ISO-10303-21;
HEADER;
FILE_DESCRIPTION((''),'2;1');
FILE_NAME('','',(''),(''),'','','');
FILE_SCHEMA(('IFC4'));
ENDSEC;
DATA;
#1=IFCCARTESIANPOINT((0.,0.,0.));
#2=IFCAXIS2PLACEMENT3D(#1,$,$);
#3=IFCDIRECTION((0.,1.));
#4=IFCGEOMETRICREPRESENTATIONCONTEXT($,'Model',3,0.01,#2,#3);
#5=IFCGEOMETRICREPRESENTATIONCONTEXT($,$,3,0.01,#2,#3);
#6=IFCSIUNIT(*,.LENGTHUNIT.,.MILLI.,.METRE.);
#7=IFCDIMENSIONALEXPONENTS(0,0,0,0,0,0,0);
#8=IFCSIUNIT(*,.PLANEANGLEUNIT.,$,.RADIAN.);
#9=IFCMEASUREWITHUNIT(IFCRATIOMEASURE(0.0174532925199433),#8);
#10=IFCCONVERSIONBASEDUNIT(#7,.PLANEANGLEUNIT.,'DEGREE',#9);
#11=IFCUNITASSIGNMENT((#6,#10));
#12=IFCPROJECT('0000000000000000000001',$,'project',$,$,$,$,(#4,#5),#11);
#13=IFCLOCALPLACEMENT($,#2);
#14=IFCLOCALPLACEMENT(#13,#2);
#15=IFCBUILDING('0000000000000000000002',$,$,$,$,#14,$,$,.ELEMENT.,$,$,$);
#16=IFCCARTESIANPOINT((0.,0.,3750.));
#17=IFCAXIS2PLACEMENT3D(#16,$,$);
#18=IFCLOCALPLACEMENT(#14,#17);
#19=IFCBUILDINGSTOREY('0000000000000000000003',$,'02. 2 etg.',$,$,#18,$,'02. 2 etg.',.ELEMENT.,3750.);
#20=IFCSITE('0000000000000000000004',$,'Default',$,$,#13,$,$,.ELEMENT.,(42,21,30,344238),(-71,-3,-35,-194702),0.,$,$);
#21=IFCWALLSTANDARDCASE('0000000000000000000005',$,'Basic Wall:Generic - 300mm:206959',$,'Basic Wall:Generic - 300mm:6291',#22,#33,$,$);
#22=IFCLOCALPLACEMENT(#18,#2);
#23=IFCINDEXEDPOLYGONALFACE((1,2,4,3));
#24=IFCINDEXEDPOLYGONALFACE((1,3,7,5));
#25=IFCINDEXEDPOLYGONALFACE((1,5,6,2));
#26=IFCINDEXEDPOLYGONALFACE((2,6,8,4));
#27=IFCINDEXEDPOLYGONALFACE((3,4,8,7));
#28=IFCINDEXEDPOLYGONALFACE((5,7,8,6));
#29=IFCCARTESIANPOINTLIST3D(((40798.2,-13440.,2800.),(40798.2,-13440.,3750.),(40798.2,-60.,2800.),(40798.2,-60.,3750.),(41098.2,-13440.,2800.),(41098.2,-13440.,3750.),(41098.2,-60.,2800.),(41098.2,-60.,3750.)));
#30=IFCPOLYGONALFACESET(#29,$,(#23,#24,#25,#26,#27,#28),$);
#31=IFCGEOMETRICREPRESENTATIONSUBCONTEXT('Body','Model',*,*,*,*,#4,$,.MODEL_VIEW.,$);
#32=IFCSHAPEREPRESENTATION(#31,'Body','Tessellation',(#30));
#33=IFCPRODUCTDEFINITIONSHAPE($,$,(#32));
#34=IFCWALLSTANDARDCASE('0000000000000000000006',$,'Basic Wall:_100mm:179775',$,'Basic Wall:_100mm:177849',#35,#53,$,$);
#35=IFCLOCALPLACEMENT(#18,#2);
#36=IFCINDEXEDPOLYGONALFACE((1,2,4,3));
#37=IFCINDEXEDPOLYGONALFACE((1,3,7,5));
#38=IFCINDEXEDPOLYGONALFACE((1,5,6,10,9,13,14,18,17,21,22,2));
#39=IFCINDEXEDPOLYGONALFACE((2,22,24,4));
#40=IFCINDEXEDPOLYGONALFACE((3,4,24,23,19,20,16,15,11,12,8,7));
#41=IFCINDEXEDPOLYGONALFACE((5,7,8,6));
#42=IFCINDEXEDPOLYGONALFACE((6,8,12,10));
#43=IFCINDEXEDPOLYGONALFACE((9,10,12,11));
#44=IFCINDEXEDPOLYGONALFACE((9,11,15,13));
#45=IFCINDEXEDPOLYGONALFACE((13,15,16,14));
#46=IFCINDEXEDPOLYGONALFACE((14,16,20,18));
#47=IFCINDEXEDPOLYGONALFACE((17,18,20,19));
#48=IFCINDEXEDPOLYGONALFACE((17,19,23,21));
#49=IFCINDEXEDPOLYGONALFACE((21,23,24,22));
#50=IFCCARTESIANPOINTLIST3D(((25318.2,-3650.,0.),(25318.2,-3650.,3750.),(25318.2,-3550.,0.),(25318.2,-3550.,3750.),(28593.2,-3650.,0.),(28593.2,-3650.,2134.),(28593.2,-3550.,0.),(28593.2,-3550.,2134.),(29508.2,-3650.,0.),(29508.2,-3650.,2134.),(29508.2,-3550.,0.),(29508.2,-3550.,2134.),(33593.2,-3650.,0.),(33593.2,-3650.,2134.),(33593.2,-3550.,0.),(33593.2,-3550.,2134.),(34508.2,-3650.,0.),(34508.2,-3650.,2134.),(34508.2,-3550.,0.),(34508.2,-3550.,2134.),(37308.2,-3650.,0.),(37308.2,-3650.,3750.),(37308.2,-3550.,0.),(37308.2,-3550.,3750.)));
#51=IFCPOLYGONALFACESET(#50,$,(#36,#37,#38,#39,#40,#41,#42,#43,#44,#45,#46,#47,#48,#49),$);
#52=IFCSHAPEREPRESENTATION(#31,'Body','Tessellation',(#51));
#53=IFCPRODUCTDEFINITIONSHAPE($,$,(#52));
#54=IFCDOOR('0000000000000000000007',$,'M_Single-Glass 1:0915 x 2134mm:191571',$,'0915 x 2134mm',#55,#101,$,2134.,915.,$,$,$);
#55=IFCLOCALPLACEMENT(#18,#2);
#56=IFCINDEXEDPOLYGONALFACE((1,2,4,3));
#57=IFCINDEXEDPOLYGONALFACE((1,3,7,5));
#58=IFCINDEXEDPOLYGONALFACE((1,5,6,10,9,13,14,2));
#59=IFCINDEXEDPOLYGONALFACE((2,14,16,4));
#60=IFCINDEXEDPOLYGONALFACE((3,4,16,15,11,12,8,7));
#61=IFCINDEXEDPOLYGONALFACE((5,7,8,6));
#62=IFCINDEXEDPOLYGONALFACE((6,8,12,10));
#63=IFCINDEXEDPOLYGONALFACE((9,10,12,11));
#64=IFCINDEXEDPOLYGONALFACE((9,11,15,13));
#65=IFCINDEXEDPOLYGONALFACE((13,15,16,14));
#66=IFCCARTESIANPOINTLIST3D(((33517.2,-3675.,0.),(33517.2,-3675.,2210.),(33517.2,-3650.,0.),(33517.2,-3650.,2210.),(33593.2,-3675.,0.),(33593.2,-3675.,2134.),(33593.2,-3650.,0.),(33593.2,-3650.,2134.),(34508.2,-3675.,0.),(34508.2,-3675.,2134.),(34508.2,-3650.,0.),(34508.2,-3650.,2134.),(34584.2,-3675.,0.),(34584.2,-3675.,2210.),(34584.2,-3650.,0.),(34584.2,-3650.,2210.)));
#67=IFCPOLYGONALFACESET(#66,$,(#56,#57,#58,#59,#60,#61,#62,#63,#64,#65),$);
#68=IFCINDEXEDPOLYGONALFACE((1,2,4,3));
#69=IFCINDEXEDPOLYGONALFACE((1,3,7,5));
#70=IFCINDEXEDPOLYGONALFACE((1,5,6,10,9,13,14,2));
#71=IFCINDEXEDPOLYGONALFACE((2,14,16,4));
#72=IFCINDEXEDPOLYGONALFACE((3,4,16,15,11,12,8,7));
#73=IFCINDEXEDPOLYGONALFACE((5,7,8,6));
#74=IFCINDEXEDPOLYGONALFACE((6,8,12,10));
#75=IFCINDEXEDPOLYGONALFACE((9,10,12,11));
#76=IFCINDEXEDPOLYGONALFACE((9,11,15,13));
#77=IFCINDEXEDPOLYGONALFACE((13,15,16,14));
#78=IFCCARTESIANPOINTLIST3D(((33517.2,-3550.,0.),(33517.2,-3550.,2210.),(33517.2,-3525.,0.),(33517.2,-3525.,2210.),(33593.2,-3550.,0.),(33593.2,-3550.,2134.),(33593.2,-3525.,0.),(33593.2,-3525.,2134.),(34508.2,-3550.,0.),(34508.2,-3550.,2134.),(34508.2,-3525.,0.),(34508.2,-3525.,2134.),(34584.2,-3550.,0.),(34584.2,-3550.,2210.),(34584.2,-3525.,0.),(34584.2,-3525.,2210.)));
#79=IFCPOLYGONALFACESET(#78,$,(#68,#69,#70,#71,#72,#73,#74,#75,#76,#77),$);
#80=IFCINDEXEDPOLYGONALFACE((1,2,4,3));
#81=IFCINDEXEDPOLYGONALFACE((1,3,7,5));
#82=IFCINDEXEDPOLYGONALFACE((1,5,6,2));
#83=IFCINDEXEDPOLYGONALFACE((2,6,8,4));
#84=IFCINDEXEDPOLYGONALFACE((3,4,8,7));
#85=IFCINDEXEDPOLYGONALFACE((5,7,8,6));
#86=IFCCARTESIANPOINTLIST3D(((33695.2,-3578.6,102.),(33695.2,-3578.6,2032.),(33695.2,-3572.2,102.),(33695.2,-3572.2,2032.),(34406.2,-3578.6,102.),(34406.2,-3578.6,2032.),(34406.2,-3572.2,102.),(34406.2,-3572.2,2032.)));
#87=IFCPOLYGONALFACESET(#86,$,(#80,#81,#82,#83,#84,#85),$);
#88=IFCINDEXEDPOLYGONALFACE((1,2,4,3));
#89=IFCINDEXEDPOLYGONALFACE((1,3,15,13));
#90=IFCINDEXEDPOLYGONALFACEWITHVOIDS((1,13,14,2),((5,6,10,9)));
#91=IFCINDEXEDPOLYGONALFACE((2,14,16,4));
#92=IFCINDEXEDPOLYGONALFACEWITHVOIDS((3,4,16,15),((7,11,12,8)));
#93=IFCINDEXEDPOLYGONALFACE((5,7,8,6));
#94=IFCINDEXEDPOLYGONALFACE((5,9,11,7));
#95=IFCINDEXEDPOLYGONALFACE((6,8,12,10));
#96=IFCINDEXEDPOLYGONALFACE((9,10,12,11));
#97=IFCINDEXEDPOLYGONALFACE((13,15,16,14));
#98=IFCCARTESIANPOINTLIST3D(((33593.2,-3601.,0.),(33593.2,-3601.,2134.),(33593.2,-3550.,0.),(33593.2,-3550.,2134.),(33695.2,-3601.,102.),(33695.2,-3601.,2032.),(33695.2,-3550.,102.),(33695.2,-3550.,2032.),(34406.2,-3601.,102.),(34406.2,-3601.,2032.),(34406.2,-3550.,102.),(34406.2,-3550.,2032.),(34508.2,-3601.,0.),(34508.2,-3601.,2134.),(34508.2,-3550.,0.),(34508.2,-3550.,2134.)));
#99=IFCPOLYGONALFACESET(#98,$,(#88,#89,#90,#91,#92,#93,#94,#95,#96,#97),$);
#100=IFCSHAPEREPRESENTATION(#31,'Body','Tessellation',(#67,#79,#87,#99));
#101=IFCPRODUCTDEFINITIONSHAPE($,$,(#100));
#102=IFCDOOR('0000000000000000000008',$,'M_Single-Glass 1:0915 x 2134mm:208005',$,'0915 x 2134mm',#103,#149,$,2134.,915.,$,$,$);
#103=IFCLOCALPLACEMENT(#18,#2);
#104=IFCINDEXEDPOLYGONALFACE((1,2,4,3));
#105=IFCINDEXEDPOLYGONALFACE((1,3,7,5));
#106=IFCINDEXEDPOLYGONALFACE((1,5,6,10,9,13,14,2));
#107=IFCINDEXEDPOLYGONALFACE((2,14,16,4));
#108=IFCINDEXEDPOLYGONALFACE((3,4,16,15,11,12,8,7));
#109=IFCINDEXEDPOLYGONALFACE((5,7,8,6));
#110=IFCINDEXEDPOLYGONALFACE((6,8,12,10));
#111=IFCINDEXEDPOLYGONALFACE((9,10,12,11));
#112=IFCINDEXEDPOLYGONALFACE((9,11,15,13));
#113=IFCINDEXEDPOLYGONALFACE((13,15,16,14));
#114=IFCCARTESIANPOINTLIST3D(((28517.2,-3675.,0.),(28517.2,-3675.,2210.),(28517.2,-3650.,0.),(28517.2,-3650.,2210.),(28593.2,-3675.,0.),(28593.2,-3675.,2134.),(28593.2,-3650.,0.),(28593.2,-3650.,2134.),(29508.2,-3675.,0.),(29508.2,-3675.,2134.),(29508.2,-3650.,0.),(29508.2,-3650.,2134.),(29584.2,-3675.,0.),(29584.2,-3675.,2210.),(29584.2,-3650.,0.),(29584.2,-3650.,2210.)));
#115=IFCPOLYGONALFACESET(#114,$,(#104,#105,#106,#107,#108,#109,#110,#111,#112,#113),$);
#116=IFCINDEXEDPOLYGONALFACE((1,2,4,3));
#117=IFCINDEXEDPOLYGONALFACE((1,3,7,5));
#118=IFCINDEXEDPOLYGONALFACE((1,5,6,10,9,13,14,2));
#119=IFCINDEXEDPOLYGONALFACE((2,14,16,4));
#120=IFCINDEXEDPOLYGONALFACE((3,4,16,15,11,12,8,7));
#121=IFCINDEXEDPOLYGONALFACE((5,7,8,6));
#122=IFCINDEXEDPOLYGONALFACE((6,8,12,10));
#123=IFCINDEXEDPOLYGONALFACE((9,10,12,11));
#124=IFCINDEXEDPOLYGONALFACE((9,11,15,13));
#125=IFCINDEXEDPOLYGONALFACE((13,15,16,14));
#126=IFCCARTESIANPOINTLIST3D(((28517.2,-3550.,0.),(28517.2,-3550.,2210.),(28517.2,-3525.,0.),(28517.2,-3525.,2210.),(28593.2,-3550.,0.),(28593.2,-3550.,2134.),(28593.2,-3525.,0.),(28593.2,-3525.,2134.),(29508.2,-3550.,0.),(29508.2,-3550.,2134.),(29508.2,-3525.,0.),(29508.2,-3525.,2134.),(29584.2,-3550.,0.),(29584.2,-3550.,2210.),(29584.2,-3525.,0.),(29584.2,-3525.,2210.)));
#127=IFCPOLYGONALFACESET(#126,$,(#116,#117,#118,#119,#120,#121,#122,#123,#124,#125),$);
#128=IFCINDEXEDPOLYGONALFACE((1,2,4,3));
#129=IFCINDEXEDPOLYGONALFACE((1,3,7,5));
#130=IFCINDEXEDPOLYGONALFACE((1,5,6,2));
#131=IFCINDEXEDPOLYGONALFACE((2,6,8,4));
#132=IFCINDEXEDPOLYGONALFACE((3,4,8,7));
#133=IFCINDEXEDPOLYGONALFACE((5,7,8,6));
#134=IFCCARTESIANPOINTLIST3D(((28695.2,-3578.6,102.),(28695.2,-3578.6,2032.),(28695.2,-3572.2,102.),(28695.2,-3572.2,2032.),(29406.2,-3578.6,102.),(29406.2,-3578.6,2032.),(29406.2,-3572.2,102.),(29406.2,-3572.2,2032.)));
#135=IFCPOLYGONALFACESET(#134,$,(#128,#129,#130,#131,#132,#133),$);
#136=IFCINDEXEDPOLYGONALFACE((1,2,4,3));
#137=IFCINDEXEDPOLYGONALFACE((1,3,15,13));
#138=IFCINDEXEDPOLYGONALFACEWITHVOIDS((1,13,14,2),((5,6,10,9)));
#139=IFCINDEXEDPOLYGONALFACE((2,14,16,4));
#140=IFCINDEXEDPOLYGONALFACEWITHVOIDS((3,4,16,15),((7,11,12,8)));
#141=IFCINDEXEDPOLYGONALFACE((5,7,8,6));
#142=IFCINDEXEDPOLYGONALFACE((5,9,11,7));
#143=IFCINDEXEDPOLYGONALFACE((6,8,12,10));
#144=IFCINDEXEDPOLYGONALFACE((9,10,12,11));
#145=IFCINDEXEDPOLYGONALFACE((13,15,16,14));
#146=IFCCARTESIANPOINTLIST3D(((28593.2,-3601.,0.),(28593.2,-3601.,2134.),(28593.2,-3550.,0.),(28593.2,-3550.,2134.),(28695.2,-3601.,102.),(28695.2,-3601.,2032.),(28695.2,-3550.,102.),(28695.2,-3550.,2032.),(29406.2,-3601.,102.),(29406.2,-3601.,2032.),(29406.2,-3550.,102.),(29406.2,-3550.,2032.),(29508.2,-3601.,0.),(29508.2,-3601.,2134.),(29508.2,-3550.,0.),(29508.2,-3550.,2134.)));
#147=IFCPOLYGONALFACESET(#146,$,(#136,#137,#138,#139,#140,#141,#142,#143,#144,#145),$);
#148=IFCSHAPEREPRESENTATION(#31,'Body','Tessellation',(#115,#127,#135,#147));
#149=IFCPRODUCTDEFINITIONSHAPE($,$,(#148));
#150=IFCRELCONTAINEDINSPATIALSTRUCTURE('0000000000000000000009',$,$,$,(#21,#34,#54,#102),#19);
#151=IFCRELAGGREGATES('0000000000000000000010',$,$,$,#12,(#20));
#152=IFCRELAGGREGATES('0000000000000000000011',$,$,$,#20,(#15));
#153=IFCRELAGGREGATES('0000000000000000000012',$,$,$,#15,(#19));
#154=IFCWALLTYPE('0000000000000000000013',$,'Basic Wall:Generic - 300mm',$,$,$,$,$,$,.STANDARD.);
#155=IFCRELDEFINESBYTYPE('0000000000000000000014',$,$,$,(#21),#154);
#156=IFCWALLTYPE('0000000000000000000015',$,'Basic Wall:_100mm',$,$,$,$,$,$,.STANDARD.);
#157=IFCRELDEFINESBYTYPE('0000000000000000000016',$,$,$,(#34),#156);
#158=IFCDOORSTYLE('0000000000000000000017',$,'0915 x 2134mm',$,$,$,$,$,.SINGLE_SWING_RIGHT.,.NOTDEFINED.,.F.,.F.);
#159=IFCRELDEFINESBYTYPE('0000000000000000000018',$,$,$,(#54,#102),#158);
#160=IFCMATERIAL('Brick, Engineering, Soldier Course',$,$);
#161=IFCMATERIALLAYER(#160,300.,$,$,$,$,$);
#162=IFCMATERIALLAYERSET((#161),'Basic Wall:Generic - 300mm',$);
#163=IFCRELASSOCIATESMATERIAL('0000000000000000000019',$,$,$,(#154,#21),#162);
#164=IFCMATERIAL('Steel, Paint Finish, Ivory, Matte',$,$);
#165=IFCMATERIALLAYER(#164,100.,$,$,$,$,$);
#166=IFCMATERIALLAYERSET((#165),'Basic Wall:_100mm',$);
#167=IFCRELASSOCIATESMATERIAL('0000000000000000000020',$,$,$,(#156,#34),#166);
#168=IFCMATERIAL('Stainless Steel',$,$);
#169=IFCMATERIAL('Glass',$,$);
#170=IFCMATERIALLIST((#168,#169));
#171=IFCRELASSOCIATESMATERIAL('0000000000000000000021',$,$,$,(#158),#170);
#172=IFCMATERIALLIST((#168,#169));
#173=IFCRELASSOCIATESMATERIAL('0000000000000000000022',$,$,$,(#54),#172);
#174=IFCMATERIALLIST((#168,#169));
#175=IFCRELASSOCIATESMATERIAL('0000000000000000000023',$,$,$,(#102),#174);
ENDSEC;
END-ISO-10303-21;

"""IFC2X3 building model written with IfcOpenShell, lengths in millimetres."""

from ifc_helpers import new_model, entity, si_unit, converted_unit, direction, frame, frame_2d, origin, place, context, subcontext, project, spatial, polyline, rectangle, outline, extrude, source, transform, mapped, material, material_list, layer, layer_set, layer_usage, type_object, type_shapes, element, fill, save


model = new_model("IFC2X3")

# Units and contexts
model_context = context("Model", 3, precision=0.01, world=origin(), true_north=direction((0.0, 1.0)))
context_of_model = context(None, 3, precision=0.01, world=origin(), true_north=direction((0.0, 1.0)))
body_context = subcontext(model_context, "Body", "Model", "MODEL_VIEW")
ifc_project = project(units=[si_unit("LENGTHUNIT", "METRE", prefix="MILLI"), converted_unit("PLANEANGLEUNIT", "DEGREE", entity("IfcRatioMeasure", 0.0174532925199433), si_unit("PLANEANGLEUNIT", "RADIAN"), dimensions=[0, 0, 0, 0, 0, 0, 0])], contexts=[model_context, context_of_model])

# Site, building, storey
site_placement = place(None, origin())
site = spatial("IfcSite", under=ifc_project, at=site_placement, Name="Default", CompositionType="ELEMENT", RefLatitude=(42, 21, 30, 344238), RefLongitude=(-71, -3, -35, -194702), RefElevation=0.0)
building_placement = place(site_placement, origin())
building = spatial("IfcBuilding", under=site, at=building_placement, CompositionType="ELEMENT")
storey_placement = place(building_placement, frame((0.0, 0.0, 3750.0)))
storey = spatial("IfcBuildingStorey", under=building, at=storey_placement, Name="02. 2 etg.", LongName="02. 2 etg.", CompositionType="ELEMENT", Elevation=3750.0)

# Shared definitions
ifc_material_1 = material(Name="Brick, Engineering, Soldier Course")
ifc_layer_1 = layer(ifc_material_1, 300.0)
ifc_layer_set_1 = layer_set([ifc_layer_1], Name="Basic Wall:Generic - 300mm")
wall_type_1 = type_object("IfcWallType", Name="Basic Wall:Generic - 300mm", PredefinedType="STANDARD", material=ifc_layer_set_1)

# Shared definitions
ifc_material_2 = material(Name="Glass")
ifc_material_3 = material(Name="Stainless Steel")

# Wall
ifc_layer_usage_1 = layer_usage(ifc_layer_set_1, "AXIS2", "POSITIVE", -150.0)
wall_1_placement = place(storey_placement, frame((40948.2, -60.0, 2800.0), z_axis=(0.0, 0.0, 1.0), x_axis=(0.0, -1.0, 0.0)))
element("IfcWallStandardCase", 1, at=wall_1_placement, inside=storey, type_object=wall_type_1, material=ifc_layer_usage_1, Name="Basic Wall:Generic - 300mm:206959", ObjectType="Basic Wall:Generic - 300mm:6291", context=body_context, shape_type="SweptSolid", body=[
    extrude(rectangle(XDim=13380.0, YDim=300.0, at=frame_2d((6690.0, 0.0), x_axis=(-1.0, 0.0))), origin(), (0.0, 0.0, 1.0), 950.0),
])

# Wall, openings, doors
ifc_material_4 = material(Name="Steel, Paint Finish, Ivory, Matte")
ifc_layer_2 = layer(ifc_material_4, 100.0)
ifc_layer_set_2 = layer_set([ifc_layer_2], Name="Basic Wall:_100mm")
ifc_layer_usage_2 = layer_usage(ifc_layer_set_2, "AXIS2", "POSITIVE", -50.0)
wall_type_2 = type_object("IfcWallType", Name="Basic Wall:_100mm", PredefinedType="STANDARD", material=ifc_layer_set_2)
wall_2_placement = place(storey_placement, frame((25318.2, -3600.0, 0.0)))
wall_2 = element("IfcWallStandardCase", 2, at=wall_2_placement, inside=storey, type_object=wall_type_2, material=ifc_layer_usage_2, Name="Basic Wall:_100mm:179775", ObjectType="Basic Wall:_100mm:177849", context=body_context, shape_type="SweptSolid", body=[
    extrude(rectangle(XDim=11990.0, YDim=100.0, at=frame_2d((5995.0, 0.0), x_axis=(-1.0, 0.0))), origin(), (0.0, 0.0, 1.0), 3750.0),
])
opening_1_placement = place(wall_2_placement, frame((8275.0, -50.0, 0.0)))
opening_1 = element("IfcOpeningElement", 3, at=opening_1_placement, cuts=wall_2, ObjectType="Opening", context=body_context, shape_type="SweptSolid", body=[
    extrude(rectangle(XDim=915.0, YDim=2134.0, at=frame_2d((1067.0, 457.5), x_axis=(0.0, 1.0))), frame((0.0, 0.0, 0.0), z_axis=(0.0, 1.0, 0.0), x_axis=(0.0, 0.0, 1.0)), (0.0, 0.0, 1.0), 100.0),
])
opening_2_placement = place(wall_2_placement, frame((3275.0, -50.0, 0.0)))
opening_2 = element("IfcOpeningElement", 4, at=opening_2_placement, cuts=wall_2, ObjectType="Opening", context=body_context, shape_type="SweptSolid", body=[
    extrude(rectangle(XDim=915.0, YDim=2134.0, at=frame_2d((1067.0, 457.5), x_axis=(0.0, 1.0))), frame((0.0, 0.0, 0.0), z_axis=(0.0, 1.0, 0.0), x_axis=(0.0, 0.0, 1.0)), (0.0, 0.0, 1.0), 100.0),
])
ifc_material_list_1 = material_list([ifc_material_3, ifc_material_2])
ifc_material_list_2 = material_list([ifc_material_3, ifc_material_2])
door_style_1 = type_object("IfcDoorStyle", Name="0915 x 2134mm", ConstructionType="NOTDEFINED", OperationType="SINGLE_SWING_RIGHT", ParameterTakesPrecedence=False, Sizeable=False, material=ifc_material_list_2)
shared_shape_1 = source(origin(), body_context, "Body", "SweptSolid", [
    extrude(outline(polyline([(-457.5, -1048.0), (-457.5, 1086.0), (-533.5, 1086.0), (-533.5, -1124.0), (533.5, -1124.0), (533.5, 1086.0), (457.5, 1086.0), (457.5, -1048.0), (-457.5, -1048.0)])), frame((457.5, -25.0, 1086.0), z_axis=(0.0, -1.0, 0.0), x_axis=(-1.0, 0.0, 0.0)), (0.0, 0.0, -1.0), 25.0),
    extrude(outline(polyline([(-457.5, -1048.0), (-457.5, 1086.0), (-533.5, 1086.0), (-533.5, -1124.0), (533.5, -1124.0), (533.5, 1086.0), (457.5, 1086.0), (457.5, -1048.0), (-457.5, -1048.0)])), frame((457.5, 100.0, 1086.0), z_axis=(0.0, -1.0, 0.0), x_axis=(-1.0, 0.0, 0.0)), (0.0, 0.0, -1.0), 25.0),
    extrude(rectangle(XDim=6.3, YDim=711.0, at=frame_2d((0.0, 0.0), x_axis=(1.0, 0.0))), frame((457.5, 74.6, 102.0), z_axis=(0.0, 0.0, 1.0), x_axis=(0.0, 1.0, 0.0)), (0.0, 0.0, 1.0), 1930.0),
    extrude(outline(polyline([(-1067.0, -457.5), (1067.0, -457.5), (1067.0, 457.5), (-1067.0, 457.5), (-1067.0, -457.5)]), holes=[polyline([(-965.0, 355.5), (965.0, 355.5), (965.0, -355.5), (-965.0, -355.5), (-965.0, 355.5)])]), frame((457.5, 49.0, 1067.0), z_axis=(0.0, 1.0, 0.0), x_axis=(0.0, 0.0, -1.0)), (0.0, 0.0, 1.0), 51.0),
])
type_shapes(door_style_1, [shared_shape_1])
door_1_placement = place(opening_1_placement, origin())
door_1 = element("IfcDoor", 5, at=door_1_placement, inside=storey, type_object=door_style_1, material=ifc_material_list_1, Name="M_Single-Glass 1:0915 x 2134mm:191571", ObjectType="0915 x 2134mm", OverallHeight=2134.0, OverallWidth=915.0, context=body_context, shape_type="MappedRepresentation", body=[
    mapped(shared_shape_1, transform((0.0, 0.0, 0.0), scale=1.0)),
])
fill(opening_1, door_1)
ifc_material_list_3 = material_list([ifc_material_3, ifc_material_2])
door_2_placement = place(opening_2_placement, origin())
door_2 = element("IfcDoor", 6, at=door_2_placement, inside=storey, type_object=door_style_1, material=ifc_material_list_3, Name="M_Single-Glass 1:0915 x 2134mm:208005", ObjectType="0915 x 2134mm", OverallHeight=2134.0, OverallWidth=915.0, context=body_context, shape_type="MappedRepresentation", body=[
    mapped(shared_shape_1, transform((0.0, 0.0, 0.0), scale=1.0)),
])
fill(opening_2, door_2)

save(model, "model.ifc")
